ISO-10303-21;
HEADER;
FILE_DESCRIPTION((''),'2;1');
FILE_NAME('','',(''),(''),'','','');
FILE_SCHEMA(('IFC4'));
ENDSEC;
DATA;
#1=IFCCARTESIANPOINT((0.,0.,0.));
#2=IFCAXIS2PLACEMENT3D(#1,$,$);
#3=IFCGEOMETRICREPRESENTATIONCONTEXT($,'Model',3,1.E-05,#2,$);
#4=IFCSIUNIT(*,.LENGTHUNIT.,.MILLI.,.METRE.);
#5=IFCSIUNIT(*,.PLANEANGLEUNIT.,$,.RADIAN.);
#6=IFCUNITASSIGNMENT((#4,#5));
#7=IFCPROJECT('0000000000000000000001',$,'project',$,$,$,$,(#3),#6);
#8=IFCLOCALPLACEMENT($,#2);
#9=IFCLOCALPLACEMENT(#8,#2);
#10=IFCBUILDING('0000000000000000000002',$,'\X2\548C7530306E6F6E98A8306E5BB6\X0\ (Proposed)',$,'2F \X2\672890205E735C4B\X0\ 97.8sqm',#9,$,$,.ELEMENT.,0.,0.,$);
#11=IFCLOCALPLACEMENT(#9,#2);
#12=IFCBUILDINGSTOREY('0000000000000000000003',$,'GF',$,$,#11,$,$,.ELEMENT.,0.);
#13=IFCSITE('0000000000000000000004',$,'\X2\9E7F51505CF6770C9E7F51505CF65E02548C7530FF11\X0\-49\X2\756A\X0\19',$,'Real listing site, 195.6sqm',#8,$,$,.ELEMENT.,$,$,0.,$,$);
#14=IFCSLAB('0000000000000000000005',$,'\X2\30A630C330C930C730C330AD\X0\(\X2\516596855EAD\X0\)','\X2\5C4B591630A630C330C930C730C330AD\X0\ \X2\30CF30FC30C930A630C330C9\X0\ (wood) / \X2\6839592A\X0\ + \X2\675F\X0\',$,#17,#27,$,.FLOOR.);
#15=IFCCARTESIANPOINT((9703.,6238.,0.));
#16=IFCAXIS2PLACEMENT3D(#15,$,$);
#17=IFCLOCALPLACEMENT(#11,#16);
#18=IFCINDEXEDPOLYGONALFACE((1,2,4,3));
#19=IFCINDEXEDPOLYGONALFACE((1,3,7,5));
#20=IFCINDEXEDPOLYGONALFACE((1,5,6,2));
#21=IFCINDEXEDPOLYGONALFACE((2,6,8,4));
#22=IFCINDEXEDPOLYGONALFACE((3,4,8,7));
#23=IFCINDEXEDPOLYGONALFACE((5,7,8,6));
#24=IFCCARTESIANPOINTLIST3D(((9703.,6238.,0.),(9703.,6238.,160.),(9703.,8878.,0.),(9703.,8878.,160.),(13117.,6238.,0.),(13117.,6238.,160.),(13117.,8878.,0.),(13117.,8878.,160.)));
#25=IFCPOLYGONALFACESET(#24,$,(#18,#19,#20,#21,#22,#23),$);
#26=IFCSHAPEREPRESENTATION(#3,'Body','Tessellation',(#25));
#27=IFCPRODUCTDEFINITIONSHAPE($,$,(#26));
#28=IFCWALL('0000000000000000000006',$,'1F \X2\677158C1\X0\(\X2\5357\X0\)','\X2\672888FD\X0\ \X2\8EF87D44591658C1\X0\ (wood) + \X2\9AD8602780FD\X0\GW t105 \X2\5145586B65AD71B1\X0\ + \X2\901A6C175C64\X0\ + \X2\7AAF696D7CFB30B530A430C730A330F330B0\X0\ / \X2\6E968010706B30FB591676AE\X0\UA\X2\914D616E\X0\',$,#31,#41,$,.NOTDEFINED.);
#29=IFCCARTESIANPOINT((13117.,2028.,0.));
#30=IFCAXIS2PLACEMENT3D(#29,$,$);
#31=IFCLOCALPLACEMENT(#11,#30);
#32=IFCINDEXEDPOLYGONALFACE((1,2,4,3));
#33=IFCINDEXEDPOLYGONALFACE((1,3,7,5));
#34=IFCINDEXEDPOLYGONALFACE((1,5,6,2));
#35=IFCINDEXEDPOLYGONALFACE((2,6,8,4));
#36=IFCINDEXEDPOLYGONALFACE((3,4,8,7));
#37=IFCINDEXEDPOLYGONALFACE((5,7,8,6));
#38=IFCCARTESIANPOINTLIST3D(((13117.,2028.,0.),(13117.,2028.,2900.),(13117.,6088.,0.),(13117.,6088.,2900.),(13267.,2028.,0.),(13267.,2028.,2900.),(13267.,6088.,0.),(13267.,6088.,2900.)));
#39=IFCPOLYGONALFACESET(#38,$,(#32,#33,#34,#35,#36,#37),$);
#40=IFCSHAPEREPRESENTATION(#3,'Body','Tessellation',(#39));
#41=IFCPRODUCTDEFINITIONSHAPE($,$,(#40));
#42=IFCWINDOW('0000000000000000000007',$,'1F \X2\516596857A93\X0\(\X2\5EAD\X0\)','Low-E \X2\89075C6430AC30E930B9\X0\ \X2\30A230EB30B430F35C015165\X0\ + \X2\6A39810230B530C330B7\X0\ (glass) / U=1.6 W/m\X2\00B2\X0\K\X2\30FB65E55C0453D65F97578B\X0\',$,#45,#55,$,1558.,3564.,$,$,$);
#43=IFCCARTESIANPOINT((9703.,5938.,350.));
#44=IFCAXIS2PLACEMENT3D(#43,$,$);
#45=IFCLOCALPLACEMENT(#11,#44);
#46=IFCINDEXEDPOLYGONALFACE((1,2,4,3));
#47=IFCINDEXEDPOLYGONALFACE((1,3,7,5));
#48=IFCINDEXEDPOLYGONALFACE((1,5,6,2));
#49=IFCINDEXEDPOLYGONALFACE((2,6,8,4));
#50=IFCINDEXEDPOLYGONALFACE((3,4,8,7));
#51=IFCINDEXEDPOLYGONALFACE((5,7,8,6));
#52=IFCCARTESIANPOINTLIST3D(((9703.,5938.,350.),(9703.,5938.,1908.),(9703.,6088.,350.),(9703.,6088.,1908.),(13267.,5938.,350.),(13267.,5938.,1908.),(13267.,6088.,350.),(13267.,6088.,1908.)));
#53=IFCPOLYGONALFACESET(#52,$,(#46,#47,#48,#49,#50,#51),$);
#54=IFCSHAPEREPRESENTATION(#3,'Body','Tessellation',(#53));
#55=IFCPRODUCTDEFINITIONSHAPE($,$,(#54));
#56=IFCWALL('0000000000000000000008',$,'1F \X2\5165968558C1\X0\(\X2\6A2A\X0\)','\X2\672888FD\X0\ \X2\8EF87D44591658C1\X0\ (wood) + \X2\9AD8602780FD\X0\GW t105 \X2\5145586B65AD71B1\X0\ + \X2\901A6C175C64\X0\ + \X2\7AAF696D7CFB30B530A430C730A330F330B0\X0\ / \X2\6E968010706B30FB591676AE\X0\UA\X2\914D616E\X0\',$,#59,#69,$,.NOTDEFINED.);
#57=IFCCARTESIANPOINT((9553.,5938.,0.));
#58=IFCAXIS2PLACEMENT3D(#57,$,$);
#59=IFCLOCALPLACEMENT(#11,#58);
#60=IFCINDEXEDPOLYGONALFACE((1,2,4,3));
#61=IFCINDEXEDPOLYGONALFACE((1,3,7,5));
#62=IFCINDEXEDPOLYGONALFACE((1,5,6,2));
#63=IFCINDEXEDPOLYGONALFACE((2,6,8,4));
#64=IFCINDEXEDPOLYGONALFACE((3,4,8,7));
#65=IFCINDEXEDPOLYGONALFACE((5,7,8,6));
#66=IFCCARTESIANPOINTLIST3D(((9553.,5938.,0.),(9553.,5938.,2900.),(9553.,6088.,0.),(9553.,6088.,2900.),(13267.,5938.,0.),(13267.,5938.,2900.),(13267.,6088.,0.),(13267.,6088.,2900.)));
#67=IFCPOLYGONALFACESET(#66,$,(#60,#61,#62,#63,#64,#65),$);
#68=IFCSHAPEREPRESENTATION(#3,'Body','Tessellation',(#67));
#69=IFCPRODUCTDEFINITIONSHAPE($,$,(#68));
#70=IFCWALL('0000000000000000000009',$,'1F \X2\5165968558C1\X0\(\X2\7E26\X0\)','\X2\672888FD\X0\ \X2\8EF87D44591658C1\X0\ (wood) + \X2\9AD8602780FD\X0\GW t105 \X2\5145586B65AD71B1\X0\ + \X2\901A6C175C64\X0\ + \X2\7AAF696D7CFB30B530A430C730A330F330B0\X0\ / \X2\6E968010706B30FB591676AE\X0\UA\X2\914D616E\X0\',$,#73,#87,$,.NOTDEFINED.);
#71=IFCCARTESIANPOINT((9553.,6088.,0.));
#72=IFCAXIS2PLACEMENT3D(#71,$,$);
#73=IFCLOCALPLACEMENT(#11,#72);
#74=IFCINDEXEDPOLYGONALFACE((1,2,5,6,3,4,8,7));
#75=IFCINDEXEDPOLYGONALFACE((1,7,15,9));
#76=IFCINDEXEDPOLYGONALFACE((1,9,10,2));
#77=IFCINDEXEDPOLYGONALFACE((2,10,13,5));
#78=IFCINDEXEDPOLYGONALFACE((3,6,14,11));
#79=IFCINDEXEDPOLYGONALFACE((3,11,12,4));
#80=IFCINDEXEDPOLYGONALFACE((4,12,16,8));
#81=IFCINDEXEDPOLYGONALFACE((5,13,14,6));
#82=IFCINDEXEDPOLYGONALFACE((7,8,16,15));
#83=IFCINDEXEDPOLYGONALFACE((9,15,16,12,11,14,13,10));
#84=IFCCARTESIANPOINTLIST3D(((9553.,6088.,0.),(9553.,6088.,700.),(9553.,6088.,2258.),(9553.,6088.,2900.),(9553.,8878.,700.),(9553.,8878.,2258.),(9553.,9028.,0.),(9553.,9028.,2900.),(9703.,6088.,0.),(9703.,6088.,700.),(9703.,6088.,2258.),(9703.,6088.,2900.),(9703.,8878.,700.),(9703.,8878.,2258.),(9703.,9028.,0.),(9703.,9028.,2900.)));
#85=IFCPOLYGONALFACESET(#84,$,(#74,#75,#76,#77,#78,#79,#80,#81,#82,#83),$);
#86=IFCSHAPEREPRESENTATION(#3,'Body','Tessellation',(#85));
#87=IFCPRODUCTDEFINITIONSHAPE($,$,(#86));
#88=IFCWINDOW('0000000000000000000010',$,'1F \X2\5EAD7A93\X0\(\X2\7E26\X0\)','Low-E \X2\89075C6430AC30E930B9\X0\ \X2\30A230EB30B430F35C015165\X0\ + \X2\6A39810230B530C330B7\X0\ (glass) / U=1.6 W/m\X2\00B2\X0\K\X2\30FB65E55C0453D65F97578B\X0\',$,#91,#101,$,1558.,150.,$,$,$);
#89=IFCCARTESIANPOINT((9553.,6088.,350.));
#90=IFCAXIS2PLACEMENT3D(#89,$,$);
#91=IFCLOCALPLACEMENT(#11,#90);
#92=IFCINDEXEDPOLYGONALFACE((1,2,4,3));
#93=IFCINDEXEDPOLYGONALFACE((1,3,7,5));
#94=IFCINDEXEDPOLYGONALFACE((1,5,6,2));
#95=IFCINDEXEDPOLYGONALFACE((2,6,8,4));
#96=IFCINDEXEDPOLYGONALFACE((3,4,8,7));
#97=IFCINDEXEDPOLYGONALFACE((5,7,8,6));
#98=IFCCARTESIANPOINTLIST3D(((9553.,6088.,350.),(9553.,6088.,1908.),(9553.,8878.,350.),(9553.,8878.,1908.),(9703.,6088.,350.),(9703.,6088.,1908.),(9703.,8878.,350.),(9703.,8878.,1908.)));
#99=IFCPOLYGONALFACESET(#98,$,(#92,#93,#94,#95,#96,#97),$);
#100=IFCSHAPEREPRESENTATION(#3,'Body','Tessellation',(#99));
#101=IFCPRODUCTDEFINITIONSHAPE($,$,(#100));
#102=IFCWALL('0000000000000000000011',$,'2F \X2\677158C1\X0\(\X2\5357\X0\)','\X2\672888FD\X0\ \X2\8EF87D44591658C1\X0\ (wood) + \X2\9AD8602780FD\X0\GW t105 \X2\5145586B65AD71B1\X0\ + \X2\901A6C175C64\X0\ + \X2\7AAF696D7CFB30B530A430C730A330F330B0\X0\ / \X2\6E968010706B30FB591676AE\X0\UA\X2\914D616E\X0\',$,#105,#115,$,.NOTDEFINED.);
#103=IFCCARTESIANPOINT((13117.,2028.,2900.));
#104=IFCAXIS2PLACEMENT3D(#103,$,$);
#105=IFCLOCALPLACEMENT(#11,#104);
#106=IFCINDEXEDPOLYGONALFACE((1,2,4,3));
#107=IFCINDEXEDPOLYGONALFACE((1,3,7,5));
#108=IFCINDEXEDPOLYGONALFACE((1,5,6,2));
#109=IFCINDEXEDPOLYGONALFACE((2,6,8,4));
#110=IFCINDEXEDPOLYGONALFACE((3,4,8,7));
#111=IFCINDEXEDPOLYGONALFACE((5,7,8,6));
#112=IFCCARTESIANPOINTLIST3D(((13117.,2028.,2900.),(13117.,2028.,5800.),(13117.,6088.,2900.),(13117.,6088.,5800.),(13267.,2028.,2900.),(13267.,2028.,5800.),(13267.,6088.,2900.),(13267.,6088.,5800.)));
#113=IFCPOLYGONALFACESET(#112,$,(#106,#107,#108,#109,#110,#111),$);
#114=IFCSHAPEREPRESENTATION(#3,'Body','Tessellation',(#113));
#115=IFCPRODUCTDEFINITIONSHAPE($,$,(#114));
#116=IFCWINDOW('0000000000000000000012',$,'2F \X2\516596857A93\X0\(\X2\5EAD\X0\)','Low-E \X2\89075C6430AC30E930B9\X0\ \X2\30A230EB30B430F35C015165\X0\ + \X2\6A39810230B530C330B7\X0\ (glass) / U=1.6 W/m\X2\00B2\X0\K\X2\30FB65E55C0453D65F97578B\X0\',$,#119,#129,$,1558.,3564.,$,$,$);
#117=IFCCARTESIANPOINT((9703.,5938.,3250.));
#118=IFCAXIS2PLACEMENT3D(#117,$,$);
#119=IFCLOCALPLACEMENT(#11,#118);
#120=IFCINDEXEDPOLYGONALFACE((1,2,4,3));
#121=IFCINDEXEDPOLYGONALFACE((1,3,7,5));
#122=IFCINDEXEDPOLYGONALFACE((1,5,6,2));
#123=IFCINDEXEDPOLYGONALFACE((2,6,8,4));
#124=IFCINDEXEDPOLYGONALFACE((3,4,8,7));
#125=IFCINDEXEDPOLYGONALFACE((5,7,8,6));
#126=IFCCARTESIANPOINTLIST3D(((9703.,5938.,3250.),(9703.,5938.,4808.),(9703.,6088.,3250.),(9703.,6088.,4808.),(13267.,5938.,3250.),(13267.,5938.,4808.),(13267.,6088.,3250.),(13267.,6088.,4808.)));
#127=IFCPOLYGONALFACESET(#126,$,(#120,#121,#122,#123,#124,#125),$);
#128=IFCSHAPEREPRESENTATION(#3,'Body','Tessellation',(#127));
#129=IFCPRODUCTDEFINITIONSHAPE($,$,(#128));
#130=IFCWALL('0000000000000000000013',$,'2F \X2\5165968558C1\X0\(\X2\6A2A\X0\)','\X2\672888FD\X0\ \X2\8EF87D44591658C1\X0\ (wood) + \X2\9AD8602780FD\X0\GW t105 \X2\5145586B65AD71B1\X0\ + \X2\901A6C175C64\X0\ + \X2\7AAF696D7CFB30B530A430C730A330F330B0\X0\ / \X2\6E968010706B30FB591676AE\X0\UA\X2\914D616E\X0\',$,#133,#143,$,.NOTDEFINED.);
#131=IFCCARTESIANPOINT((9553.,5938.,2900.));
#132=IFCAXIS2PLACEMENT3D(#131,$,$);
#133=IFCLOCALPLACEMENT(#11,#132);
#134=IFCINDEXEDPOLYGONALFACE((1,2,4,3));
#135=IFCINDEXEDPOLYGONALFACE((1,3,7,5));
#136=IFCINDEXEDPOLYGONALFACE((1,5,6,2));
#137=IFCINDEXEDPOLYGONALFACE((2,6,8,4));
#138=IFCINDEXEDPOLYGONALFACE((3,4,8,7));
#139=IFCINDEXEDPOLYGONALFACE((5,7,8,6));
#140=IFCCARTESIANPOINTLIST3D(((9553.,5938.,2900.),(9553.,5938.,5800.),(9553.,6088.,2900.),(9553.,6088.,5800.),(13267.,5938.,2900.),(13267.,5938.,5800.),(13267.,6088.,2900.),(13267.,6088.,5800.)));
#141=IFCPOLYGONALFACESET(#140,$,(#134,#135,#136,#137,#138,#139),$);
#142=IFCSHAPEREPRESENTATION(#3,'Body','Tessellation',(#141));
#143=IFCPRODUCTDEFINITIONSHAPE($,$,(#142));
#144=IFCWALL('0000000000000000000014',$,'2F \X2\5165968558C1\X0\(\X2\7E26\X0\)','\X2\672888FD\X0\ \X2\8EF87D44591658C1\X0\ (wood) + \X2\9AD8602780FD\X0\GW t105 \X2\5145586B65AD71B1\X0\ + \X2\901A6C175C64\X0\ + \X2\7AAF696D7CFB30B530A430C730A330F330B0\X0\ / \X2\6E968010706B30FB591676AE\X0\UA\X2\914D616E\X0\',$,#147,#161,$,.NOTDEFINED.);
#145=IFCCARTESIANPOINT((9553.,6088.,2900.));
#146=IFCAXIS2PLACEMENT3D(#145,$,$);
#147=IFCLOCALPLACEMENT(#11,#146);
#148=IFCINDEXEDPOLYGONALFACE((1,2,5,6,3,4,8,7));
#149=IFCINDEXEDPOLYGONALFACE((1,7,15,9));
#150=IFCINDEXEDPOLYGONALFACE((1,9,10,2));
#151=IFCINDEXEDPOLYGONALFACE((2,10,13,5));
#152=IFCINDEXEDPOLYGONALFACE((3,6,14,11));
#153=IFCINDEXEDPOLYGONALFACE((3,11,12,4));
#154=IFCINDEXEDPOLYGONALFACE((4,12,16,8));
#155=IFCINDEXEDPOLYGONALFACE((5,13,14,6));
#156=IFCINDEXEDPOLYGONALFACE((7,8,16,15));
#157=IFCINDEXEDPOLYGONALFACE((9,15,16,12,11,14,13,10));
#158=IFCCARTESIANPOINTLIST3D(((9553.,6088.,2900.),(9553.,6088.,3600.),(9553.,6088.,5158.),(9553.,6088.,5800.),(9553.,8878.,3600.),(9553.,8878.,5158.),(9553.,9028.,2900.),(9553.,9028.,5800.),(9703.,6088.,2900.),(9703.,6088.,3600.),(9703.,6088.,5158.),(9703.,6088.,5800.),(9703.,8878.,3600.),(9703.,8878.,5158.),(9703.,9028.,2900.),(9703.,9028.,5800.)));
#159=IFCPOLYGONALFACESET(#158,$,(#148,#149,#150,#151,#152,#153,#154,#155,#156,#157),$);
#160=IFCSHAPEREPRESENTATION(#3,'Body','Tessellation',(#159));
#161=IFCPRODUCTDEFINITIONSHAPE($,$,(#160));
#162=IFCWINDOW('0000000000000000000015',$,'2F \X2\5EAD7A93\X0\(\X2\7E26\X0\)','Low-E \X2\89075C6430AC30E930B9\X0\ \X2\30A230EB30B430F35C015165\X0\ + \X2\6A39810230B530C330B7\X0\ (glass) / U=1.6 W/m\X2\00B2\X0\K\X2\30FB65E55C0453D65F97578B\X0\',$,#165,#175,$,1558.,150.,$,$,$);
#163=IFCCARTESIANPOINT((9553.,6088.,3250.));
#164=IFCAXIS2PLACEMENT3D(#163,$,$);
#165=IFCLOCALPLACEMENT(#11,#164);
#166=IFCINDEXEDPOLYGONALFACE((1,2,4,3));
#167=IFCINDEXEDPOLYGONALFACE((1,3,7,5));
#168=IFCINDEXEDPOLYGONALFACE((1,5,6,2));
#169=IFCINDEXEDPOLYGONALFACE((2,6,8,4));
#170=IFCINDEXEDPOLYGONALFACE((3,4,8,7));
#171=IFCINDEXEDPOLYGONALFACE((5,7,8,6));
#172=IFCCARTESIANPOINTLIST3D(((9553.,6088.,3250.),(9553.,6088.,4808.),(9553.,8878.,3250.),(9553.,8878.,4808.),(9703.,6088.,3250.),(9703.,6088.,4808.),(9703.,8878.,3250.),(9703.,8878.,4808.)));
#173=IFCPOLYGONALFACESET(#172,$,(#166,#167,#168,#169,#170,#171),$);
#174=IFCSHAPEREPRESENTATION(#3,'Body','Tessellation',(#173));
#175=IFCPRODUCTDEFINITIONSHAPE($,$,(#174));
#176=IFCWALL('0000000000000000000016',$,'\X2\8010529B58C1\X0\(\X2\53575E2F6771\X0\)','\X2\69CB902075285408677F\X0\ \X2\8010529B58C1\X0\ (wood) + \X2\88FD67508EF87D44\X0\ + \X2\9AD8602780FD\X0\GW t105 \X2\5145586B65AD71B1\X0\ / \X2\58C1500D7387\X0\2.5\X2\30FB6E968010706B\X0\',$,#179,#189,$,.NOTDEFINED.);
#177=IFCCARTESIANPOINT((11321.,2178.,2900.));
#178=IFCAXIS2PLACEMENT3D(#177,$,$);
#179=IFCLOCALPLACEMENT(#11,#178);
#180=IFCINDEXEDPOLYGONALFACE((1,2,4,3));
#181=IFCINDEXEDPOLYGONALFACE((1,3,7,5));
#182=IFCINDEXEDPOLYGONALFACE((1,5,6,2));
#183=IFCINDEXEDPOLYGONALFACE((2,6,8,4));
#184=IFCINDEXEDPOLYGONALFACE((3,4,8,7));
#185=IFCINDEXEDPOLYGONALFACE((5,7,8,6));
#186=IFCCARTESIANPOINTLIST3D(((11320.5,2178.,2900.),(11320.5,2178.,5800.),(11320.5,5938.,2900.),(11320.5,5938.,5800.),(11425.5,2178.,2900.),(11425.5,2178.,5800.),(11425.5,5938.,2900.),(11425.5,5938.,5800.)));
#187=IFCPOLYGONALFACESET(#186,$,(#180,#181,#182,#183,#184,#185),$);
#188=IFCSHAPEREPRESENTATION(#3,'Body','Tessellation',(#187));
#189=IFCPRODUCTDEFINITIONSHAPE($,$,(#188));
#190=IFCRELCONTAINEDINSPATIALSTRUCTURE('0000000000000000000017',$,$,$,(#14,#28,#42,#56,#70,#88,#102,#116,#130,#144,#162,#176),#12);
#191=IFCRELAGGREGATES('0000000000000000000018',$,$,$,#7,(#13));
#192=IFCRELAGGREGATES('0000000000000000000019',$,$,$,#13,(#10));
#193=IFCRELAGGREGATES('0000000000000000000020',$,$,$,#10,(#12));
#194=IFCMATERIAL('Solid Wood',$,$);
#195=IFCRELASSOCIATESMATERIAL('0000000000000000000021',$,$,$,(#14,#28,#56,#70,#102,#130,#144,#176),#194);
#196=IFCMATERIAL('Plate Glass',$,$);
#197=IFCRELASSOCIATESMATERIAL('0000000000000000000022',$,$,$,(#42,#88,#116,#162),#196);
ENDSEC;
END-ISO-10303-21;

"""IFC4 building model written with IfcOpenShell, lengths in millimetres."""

from ifc_helpers import new_model, si_unit, frame, frame_2d, origin, place, context, project, spatial, rectangle, extrude, material, element, fill, save


model = new_model("IFC4")

# Units and contexts
model_context = context("Model", 3, precision=1e-05, world=origin())
ifc_project = project(units=[si_unit("LENGTHUNIT", "METRE", prefix="MILLI"), si_unit("PLANEANGLEUNIT", "RADIAN")], contexts=[model_context])

# Site, building, storey
site_placement = place(None, origin())
site = spatial("IfcSite", under=ifc_project, at=site_placement, Name="鹿児島県鹿児島市和田１-49番19", ObjectType="Real listing site, 195.6sqm", CompositionType="ELEMENT", RefElevation=0.0)
building_placement = place(site_placement, origin())
building = spatial("IfcBuilding", under=site, at=building_placement, Name="和田の潮風の家 (Proposed)", ObjectType="2F 木造平屋 97.8sqm", CompositionType="ELEMENT", ElevationOfRefHeight=0.0, ElevationOfTerrain=0.0)
storey_placement = place(building_placement, origin())
storey = spatial("IfcBuildingStorey", under=building, at=storey_placement, Name="GF", CompositionType="ELEMENT", Elevation=0.0)

# Slab
ifc_material_1 = material(Name="Solid Wood")
slab_placement = place(storey_placement, frame((9703.0, 6238.0, 0.0)))
element("IfcSlab", 1, at=slab_placement, inside=storey, material=ifc_material_1, Name="ウッドデッキ(入隅庭)", Description="屋外ウッドデッキ ハードウッド (wood) / 根太 + 束", PredefinedType="FLOOR", context=model_context, shape_type="SweptSolid", body=[
    extrude(rectangle(XDim=3414.0, YDim=2640.0, at=frame_2d((1707.0, 1320.0))), frame((9703.0, 6238.0, 0.0)), (0.0, 0.0, 1.0), 160.0),
])

# Wall, opening, window
wall_1_placement = place(storey_placement, frame((13117.0, 2028.0, 0.0)))
wall_1 = element("IfcWall", 2, at=wall_1_placement, inside=storey, material=ifc_material_1, Name="1F 東壁(南)", Description="木製 軸組外壁 (wood) + 高性能GW t105 充填断熱 + 通気層 + 窯業系サイディング / 準耐火・外皮UA配慮", PredefinedType="NOTDEFINED", context=model_context, shape_type="SweptSolid", body=[
    extrude(rectangle(XDim=150.0, YDim=4060.0, at=frame_2d((75.0, 2030.0))), frame((13117.0, 2028.0, 0.0)), (0.0, 0.0, 1.0), 2900.0),
])
opening_1_placement = place(storey_placement, frame((9703.0, 5938.0, 350.0)))
opening_1 = element("IfcOpeningElement", 3, at=opening_1_placement, cuts=wall_1, PredefinedType="NOTDEFINED", context=model_context, shape_type="SweptSolid", body=[
    extrude(rectangle(XDim=3564.0, YDim=150.0, at=frame_2d((1782.0, 75.0))), frame((9703.0, 5938.0, 350.0)), (0.0, 0.0, 1.0), 1558.0),
])
ifc_material_2 = material(Name="Plate Glass")
window_1_placement = place(storey_placement, frame((9703.0, 5938.0, 350.0)))
window_1 = element("IfcWindow", 4, at=window_1_placement, inside=storey, material=ifc_material_2, Name="1F 入隅窓(庭)", Description="Low-E 複層ガラス アルゴン封入 + 樹脂サッシ (glass) / U=1.6 W/m²K・日射取得型", OverallHeight=1558.0, OverallWidth=3564.0, context=model_context, shape_type="SweptSolid", body=[
    extrude(rectangle(XDim=3564.0, YDim=150.0, at=frame_2d((1782.0, 75.0))), frame((9703.0, 5938.0, 350.0)), (0.0, 0.0, 1.0), 1558.0),
])
fill(opening_1, window_1)

# Wall
wall_2_placement = place(storey_placement, frame((9553.0, 5938.0, 0.0)))
element("IfcWall", 5, at=wall_2_placement, inside=storey, material=ifc_material_1, Name="1F 入隅壁(横)", Description="木製 軸組外壁 (wood) + 高性能GW t105 充填断熱 + 通気層 + 窯業系サイディング / 準耐火・外皮UA配慮", PredefinedType="NOTDEFINED", context=model_context, shape_type="SweptSolid", body=[
    extrude(rectangle(XDim=3714.0, YDim=150.0, at=frame_2d((1857.0, 75.0))), frame((9553.0, 5938.0, 0.0)), (0.0, 0.0, 1.0), 2900.0),
])

# Wall, opening, window
wall_3_placement = place(storey_placement, frame((9553.0, 6088.0, 0.0)))
wall_3 = element("IfcWall", 6, at=wall_3_placement, inside=storey, material=ifc_material_1, Name="1F 入隅壁(縦)", Description="木製 軸組外壁 (wood) + 高性能GW t105 充填断熱 + 通気層 + 窯業系サイディング / 準耐火・外皮UA配慮", PredefinedType="NOTDEFINED", context=model_context, shape_type="SweptSolid", body=[
    extrude(rectangle(XDim=150.0, YDim=2940.0, at=frame_2d((75.0, 1470.0))), frame((9553.0, 6088.0, 0.0)), (0.0, 0.0, 1.0), 2900.0),
])
opening_2_placement = place(storey_placement, frame((9553.0, 6088.0, 350.0)))
opening_2 = element("IfcOpeningElement", 7, at=opening_2_placement, cuts=wall_3, PredefinedType="NOTDEFINED", context=model_context, shape_type="SweptSolid", body=[
    extrude(rectangle(XDim=150.0, YDim=2790.0, at=frame_2d((75.0, 1395.0))), frame((9553.0, 6088.0, 350.0)), (0.0, 0.0, 1.0), 1558.0),
])
window_2_placement = place(storey_placement, frame((9553.0, 6088.0, 350.0)))
window_2 = element("IfcWindow", 8, at=window_2_placement, inside=storey, material=ifc_material_2, Name="1F 庭窓(縦)", Description="Low-E 複層ガラス アルゴン封入 + 樹脂サッシ (glass) / U=1.6 W/m²K・日射取得型", OverallHeight=1558.0, OverallWidth=150.0, context=model_context, shape_type="SweptSolid", body=[
    extrude(rectangle(XDim=150.0, YDim=2790.0, at=frame_2d((75.0, 1395.0))), frame((9553.0, 6088.0, 350.0)), (0.0, 0.0, 1.0), 1558.0),
])
fill(opening_2, window_2)

# Wall, opening, window
wall_4_placement = place(storey_placement, frame((13117.0, 2028.0, 2900.0)))
wall_4 = element("IfcWall", 9, at=wall_4_placement, inside=storey, material=ifc_material_1, Name="2F 東壁(南)", Description="木製 軸組外壁 (wood) + 高性能GW t105 充填断熱 + 通気層 + 窯業系サイディング / 準耐火・外皮UA配慮", PredefinedType="NOTDEFINED", context=model_context, shape_type="SweptSolid", body=[
    extrude(rectangle(XDim=150.0, YDim=4060.0, at=frame_2d((75.0, 2030.0))), frame((13117.0, 2028.0, 2900.0)), (0.0, 0.0, 1.0), 2900.0),
])
opening_3_placement = place(storey_placement, frame((9703.0, 5938.0, 3250.0)))
opening_3 = element("IfcOpeningElement", 10, at=opening_3_placement, cuts=wall_4, PredefinedType="NOTDEFINED", context=model_context, shape_type="SweptSolid", body=[
    extrude(rectangle(XDim=3564.0, YDim=150.0, at=frame_2d((1782.0, 75.0))), frame((9703.0, 5938.0, 3250.0)), (0.0, 0.0, 1.0), 1558.0),
])
window_3_placement = place(storey_placement, frame((9703.0, 5938.0, 3250.0)))
window_3 = element("IfcWindow", 11, at=window_3_placement, inside=storey, material=ifc_material_2, Name="2F 入隅窓(庭)", Description="Low-E 複層ガラス アルゴン封入 + 樹脂サッシ (glass) / U=1.6 W/m²K・日射取得型", OverallHeight=1558.0, OverallWidth=3564.0, context=model_context, shape_type="SweptSolid", body=[
    extrude(rectangle(XDim=3564.0, YDim=150.0, at=frame_2d((1782.0, 75.0))), frame((9703.0, 5938.0, 3250.0)), (0.0, 0.0, 1.0), 1558.0),
])
fill(opening_3, window_3)

# Wall
wall_5_placement = place(storey_placement, frame((9553.0, 5938.0, 2900.0)))
element("IfcWall", 12, at=wall_5_placement, inside=storey, material=ifc_material_1, Name="2F 入隅壁(横)", Description="木製 軸組外壁 (wood) + 高性能GW t105 充填断熱 + 通気層 + 窯業系サイディング / 準耐火・外皮UA配慮", PredefinedType="NOTDEFINED", context=model_context, shape_type="SweptSolid", body=[
    extrude(rectangle(XDim=3714.0, YDim=150.0, at=frame_2d((1857.0, 75.0))), frame((9553.0, 5938.0, 2900.0)), (0.0, 0.0, 1.0), 2900.0),
])

# Wall, opening, window
wall_6_placement = place(storey_placement, frame((9553.0, 6088.0, 2900.0)))
wall_6 = element("IfcWall", 13, at=wall_6_placement, inside=storey, material=ifc_material_1, Name="2F 入隅壁(縦)", Description="木製 軸組外壁 (wood) + 高性能GW t105 充填断熱 + 通気層 + 窯業系サイディング / 準耐火・外皮UA配慮", PredefinedType="NOTDEFINED", context=model_context, shape_type="SweptSolid", body=[
    extrude(rectangle(XDim=150.0, YDim=2940.0, at=frame_2d((75.0, 1470.0))), frame((9553.0, 6088.0, 2900.0)), (0.0, 0.0, 1.0), 2900.0),
])
opening_4_placement = place(storey_placement, frame((9553.0, 6088.0, 3250.0)))
opening_4 = element("IfcOpeningElement", 14, at=opening_4_placement, cuts=wall_6, PredefinedType="NOTDEFINED", context=model_context, shape_type="SweptSolid", body=[
    extrude(rectangle(XDim=150.0, YDim=2790.0, at=frame_2d((75.0, 1395.0))), frame((9553.0, 6088.0, 3250.0)), (0.0, 0.0, 1.0), 1558.0),
])
window_4_placement = place(storey_placement, frame((9553.0, 6088.0, 3250.0)))
window_4 = element("IfcWindow", 15, at=window_4_placement, inside=storey, material=ifc_material_2, Name="2F 庭窓(縦)", Description="Low-E 複層ガラス アルゴン封入 + 樹脂サッシ (glass) / U=1.6 W/m²K・日射取得型", OverallHeight=1558.0, OverallWidth=150.0, context=model_context, shape_type="SweptSolid", body=[
    extrude(rectangle(XDim=150.0, YDim=2790.0, at=frame_2d((75.0, 1395.0))), frame((9553.0, 6088.0, 3250.0)), (0.0, 0.0, 1.0), 1558.0),
])
fill(opening_4, window_4)

# Wall
wall_7_placement = place(storey_placement, frame((11321.0, 2178.0, 2900.0)))
element("IfcWall", 16, at=wall_7_placement, inside=storey, material=ifc_material_1, Name="耐力壁(南帯東)", Description="構造用合板 耐力壁 (wood) + 製材軸組 + 高性能GW t105 充填断熱 / 壁倍率2.5・準耐火", PredefinedType="NOTDEFINED", context=model_context, shape_type="SweptSolid", body=[
    extrude(rectangle(XDim=105.0, YDim=3760.0, at=frame_2d((52.0, 1880.0))), frame((11321.0, 2178.0, 2900.0)), (0.0, 0.0, 1.0), 2900.0),
])

save(model, "model.ifc")
